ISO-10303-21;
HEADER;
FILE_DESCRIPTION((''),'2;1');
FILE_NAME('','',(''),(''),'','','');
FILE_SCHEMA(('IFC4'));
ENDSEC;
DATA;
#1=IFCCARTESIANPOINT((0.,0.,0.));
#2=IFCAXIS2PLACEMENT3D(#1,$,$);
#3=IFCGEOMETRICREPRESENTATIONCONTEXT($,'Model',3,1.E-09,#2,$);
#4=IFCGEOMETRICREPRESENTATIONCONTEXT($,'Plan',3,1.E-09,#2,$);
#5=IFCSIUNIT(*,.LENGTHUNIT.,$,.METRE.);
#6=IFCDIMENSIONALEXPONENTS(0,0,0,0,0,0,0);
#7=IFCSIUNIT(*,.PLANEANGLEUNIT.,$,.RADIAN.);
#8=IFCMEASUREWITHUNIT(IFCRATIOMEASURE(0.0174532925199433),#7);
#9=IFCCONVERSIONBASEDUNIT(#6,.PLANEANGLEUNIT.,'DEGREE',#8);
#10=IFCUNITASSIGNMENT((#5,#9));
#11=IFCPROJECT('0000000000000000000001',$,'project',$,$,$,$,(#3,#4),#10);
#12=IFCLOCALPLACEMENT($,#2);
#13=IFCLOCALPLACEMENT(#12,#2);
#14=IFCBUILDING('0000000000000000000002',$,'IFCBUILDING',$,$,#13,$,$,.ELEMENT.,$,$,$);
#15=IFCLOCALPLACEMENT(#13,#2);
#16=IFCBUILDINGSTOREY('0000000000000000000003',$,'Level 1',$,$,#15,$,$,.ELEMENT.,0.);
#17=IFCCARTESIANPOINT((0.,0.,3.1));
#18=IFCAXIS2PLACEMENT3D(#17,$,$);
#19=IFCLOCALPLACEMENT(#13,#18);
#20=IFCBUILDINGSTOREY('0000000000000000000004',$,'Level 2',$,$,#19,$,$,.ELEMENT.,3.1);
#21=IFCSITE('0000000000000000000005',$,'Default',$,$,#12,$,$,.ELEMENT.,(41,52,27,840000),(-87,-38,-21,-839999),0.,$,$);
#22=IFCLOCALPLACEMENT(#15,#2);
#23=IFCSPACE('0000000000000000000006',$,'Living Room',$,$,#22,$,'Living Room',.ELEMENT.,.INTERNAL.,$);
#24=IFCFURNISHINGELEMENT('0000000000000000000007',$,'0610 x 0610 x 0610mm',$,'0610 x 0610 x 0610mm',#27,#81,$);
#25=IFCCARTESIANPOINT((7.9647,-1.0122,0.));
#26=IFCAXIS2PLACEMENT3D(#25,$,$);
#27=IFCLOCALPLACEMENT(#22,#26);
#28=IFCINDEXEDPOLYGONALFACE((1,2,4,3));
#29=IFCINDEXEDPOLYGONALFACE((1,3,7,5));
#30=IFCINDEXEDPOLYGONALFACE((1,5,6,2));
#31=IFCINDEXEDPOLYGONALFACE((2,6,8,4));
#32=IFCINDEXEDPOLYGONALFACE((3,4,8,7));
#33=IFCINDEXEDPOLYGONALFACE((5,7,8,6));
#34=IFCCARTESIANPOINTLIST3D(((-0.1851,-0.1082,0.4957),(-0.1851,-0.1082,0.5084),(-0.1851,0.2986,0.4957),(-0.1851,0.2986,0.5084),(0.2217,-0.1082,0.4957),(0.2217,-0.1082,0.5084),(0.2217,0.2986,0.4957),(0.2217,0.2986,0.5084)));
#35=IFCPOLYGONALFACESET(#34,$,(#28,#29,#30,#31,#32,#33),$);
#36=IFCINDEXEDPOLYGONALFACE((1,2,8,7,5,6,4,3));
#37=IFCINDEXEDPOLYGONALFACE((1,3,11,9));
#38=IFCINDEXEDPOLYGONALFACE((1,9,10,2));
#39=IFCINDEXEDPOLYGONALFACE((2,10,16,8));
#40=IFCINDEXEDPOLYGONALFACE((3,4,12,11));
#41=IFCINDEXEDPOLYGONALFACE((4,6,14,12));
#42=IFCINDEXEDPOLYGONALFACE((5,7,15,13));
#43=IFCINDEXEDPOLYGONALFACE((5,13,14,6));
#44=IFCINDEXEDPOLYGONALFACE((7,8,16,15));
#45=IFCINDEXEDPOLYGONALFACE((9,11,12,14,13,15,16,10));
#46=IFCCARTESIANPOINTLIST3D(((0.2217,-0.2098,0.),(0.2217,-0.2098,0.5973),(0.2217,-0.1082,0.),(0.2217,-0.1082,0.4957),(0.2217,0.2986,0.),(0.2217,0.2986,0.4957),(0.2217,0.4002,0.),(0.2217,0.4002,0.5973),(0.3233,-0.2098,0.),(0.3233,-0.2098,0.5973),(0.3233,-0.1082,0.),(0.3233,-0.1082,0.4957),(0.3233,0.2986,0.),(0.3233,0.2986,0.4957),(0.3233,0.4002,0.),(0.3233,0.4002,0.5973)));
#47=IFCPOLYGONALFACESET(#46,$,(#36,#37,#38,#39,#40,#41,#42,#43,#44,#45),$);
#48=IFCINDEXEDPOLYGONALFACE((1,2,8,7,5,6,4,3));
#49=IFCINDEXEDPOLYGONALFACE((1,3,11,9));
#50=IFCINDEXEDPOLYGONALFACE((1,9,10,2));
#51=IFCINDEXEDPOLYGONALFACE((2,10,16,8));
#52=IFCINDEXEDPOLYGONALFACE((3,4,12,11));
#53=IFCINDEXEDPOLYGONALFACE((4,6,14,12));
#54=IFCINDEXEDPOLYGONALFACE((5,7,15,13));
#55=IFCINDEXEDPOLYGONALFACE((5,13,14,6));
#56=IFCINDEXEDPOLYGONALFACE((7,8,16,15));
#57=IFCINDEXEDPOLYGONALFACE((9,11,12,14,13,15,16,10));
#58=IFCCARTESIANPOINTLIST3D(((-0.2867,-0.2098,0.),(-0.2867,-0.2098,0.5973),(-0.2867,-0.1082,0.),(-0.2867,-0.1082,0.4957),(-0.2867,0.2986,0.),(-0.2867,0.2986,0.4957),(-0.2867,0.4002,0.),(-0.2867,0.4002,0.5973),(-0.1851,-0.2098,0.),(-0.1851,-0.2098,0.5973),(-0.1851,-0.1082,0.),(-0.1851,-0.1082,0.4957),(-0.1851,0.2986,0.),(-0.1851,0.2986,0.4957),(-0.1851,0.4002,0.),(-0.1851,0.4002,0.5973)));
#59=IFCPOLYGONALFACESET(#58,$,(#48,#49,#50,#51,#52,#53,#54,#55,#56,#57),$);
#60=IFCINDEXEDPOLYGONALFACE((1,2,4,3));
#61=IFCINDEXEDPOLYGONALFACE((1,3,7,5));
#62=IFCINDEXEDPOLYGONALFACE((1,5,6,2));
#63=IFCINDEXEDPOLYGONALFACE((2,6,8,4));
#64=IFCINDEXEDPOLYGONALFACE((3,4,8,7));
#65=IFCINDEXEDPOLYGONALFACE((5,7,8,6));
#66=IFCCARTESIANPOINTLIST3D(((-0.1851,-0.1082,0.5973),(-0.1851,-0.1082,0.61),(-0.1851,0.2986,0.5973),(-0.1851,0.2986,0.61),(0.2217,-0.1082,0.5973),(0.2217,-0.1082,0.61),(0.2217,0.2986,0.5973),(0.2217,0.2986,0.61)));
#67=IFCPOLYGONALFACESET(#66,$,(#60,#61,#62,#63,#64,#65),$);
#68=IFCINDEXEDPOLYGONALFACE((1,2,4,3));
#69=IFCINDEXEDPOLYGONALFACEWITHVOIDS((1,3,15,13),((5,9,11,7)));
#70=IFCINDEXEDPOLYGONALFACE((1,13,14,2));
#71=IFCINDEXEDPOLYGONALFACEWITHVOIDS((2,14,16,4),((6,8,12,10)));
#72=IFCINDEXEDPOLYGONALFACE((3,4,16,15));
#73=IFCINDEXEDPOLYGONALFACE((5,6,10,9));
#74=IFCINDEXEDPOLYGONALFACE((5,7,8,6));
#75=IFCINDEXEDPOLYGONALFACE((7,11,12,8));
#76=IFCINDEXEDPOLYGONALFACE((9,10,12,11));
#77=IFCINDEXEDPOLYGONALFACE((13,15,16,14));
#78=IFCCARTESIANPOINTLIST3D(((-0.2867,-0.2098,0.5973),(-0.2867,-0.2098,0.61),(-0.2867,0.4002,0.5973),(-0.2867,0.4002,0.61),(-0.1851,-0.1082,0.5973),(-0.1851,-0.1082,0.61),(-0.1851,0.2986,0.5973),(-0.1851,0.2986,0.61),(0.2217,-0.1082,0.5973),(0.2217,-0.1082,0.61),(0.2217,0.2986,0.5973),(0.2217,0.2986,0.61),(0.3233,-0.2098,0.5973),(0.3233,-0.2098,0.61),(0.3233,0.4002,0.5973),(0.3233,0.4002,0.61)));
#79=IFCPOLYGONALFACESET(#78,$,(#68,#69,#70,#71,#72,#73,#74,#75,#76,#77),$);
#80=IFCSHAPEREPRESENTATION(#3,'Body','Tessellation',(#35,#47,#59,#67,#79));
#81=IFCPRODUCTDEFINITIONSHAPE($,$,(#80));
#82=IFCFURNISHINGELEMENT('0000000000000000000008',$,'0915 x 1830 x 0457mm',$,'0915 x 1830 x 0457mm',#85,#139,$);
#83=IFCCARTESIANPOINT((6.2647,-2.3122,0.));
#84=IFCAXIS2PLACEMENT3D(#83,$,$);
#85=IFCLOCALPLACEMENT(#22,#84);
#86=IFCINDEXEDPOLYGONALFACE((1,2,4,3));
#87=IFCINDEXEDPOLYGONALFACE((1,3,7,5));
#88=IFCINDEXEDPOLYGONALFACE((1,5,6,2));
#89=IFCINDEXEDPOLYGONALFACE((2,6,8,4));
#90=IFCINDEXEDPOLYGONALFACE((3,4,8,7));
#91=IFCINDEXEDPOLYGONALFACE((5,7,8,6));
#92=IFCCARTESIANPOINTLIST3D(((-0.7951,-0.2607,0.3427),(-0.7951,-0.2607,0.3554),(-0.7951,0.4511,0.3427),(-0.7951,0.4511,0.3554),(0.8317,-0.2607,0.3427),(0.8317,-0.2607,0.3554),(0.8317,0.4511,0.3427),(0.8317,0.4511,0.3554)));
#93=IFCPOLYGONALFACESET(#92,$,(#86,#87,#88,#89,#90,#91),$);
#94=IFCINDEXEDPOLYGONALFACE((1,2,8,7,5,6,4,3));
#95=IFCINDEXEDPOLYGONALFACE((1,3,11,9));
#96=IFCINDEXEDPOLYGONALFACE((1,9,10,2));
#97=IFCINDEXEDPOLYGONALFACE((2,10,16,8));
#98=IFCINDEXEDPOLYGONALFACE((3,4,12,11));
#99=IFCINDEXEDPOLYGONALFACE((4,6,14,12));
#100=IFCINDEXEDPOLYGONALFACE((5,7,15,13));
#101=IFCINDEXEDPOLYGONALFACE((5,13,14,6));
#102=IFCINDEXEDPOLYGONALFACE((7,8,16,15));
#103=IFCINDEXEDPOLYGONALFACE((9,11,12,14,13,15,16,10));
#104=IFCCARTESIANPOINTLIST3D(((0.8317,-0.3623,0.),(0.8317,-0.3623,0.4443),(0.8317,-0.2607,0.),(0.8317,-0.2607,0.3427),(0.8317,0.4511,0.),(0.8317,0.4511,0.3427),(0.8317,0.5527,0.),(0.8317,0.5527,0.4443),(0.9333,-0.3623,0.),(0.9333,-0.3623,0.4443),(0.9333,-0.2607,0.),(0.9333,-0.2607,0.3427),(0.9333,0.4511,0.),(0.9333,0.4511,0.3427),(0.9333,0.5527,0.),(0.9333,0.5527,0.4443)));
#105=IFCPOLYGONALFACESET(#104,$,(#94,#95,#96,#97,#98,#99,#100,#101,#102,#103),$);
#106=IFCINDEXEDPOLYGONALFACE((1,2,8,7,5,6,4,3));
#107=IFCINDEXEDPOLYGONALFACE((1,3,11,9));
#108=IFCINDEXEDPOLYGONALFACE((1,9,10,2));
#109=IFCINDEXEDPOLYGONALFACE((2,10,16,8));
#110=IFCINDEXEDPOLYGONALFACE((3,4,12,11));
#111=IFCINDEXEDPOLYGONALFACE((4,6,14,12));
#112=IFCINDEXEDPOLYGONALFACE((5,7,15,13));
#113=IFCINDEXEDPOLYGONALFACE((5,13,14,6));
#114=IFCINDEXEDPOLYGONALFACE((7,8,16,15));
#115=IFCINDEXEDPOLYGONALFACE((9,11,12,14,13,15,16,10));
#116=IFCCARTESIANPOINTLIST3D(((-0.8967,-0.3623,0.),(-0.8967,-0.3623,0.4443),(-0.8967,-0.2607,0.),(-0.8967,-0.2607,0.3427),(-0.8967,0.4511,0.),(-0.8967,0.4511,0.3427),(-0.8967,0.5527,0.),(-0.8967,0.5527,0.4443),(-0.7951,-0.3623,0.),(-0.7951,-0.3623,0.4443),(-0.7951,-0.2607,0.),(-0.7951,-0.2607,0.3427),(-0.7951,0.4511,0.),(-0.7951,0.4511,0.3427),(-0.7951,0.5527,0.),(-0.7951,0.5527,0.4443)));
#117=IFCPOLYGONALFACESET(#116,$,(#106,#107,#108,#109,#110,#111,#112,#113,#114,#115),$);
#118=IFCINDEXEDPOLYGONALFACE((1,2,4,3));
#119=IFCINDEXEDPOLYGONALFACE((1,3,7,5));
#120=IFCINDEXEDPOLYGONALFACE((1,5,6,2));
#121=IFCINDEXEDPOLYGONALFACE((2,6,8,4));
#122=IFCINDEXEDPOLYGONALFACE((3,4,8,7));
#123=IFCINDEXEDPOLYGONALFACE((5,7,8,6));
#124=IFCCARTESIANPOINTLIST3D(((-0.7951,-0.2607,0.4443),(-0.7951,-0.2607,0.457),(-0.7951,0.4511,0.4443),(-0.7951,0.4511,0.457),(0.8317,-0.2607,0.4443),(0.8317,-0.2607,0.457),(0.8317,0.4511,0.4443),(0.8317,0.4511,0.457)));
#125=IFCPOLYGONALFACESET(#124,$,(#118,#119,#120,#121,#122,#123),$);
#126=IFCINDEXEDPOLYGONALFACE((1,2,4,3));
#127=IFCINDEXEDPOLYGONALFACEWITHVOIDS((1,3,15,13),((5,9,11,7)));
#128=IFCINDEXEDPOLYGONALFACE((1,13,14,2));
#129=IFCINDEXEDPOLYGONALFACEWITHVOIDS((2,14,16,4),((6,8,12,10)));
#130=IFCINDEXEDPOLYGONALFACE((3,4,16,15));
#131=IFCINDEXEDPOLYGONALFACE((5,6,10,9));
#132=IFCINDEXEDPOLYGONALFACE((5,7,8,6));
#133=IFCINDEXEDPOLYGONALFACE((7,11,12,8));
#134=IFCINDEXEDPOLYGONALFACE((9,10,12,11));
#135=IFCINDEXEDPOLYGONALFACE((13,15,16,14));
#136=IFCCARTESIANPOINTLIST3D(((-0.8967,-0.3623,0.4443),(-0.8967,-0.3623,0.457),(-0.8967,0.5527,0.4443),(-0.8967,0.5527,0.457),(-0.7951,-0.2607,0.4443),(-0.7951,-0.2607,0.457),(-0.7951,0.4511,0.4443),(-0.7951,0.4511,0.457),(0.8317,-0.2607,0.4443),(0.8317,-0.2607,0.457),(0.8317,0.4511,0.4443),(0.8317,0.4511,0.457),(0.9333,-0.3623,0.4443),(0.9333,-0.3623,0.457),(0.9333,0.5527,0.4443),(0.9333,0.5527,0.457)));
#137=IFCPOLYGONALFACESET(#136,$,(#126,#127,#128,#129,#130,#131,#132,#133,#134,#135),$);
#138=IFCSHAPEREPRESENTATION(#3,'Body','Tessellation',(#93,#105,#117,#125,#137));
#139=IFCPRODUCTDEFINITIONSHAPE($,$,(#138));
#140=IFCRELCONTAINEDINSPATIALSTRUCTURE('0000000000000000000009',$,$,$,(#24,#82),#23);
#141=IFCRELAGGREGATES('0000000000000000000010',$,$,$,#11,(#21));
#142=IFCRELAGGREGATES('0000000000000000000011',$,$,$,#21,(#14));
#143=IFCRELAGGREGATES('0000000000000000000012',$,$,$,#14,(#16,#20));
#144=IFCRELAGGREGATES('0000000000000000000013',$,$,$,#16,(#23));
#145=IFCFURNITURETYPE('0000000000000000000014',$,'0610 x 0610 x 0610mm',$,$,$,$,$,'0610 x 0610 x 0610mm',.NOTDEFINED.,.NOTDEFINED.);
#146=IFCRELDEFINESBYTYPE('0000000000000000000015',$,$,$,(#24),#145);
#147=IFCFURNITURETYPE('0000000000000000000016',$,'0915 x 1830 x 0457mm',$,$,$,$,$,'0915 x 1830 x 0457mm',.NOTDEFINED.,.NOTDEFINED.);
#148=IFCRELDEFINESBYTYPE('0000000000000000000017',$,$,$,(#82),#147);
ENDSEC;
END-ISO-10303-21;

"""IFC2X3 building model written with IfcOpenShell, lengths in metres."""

from ifc_helpers import new_model, entity, si_unit, converted_unit, frame, origin, origin_2d_with_axis, place, context, project, spatial, polyline, rectangle, outline, extrude, source, transform, mapped, type_object, type_shapes, element, save


model = new_model("IFC2X3")

# Units and contexts
model_context = context("Model", 3, precision=1e-09, world=origin())
plan_context = context("Plan", 3, precision=1e-09, world=origin())
ifc_project = project(units=[si_unit("LENGTHUNIT", "METRE"), converted_unit("PLANEANGLEUNIT", "DEGREE", entity("IfcRatioMeasure", 0.0174532925199433), si_unit("PLANEANGLEUNIT", "RADIAN"), dimensions=[0, 0, 0, 0, 0, 0, 0])], contexts=[model_context, plan_context])

# Site, building, storey
site_placement = place(None, origin())
site = spatial("IfcSite", under=ifc_project, at=site_placement, Name="Default", CompositionType="ELEMENT", RefLatitude=(41, 52, 27, 840000), RefLongitude=(-87, -38, -21, -839999), RefElevation=0.0)
building_placement = place(site_placement, origin())
building = spatial("IfcBuilding", under=site, at=building_placement, Name="IFCBUILDING", CompositionType="ELEMENT")
storey_1_placement = place(building_placement, origin())
storey_1 = spatial("IfcBuildingStorey", under=building, at=storey_1_placement, Name="Level 1", CompositionType="ELEMENT", Elevation=0.0)

# Shared definitions
storey_2_placement = place(building_placement, frame((0.0, 0.0, 3.1)))
storey_2 = spatial("IfcBuildingStorey", under=building, at=storey_2_placement, Name="Level 2", CompositionType="ELEMENT", Elevation=3.1)

# Shared definitions
space_1_placement = place(storey_1_placement, origin())
space_1 = spatial("IfcSpace", under=storey_1, at=space_1_placement, Name="Living Room", LongName="Living Room", CompositionType="ELEMENT", InteriorOrExteriorSpace="INTERNAL")

# Furnishing elements
furniture_type_1 = type_object("IfcFurnitureType", Name="0610 x 0610 x 0610mm", ElementType="0610 x 0610 x 0610mm", AssemblyPlace="NOTDEFINED")
shared_shape_1 = source(origin(), model_context, "Body", "SweptSolid", [
    extrude(rectangle(XDim=0.4068, YDim=0.4068, at=origin_2d_with_axis()), frame((0.0183, 0.0952, 0.4957), z_axis=(0.0, 0.0, 1.0), x_axis=(-1.0, 0.0, 0.0)), (0.0, 0.0, 1.0), 0.0127),
    extrude(outline(polyline([(-0.2732, -0.305), (0.324, -0.305), (0.324, 0.305), (-0.2732, 0.305), (-0.2732, 0.2034), (0.2225, 0.2034), (0.2225, -0.2034), (-0.2732, -0.2034), (-0.2732, -0.305)])), frame((0.2217, 0.0952, 0.2732), z_axis=(1.0, 0.0, 0.0), x_axis=(0.0, 0.0, 1.0)), (0.0, 0.0, 1.0), 0.1016),
    extrude(outline(polyline([(-0.305, -0.3241), (0.305, -0.3241), (0.305, 0.2733), (0.2034, 0.2733), (0.2034, -0.2224), (-0.2034, -0.2224), (-0.2034, 0.2733), (-0.305, 0.2733), (-0.305, -0.3241)])), frame((-0.2867, 0.0952, 0.2733), z_axis=(1.0, 0.0, 0.0), x_axis=(0.0, -1.0, 0.0)), (0.0, 0.0, 1.0), 0.1016),
    extrude(rectangle(XDim=0.4068, YDim=0.4068, at=origin_2d_with_axis()), frame((0.0183, 0.0952, 0.5973), z_axis=(0.0, 0.0, 1.0), x_axis=(-1.0, 0.0, 0.0)), (0.0, 0.0, 1.0), 0.0127),
    extrude(outline(polyline([(-0.305, -0.305), (0.305, -0.305), (0.305, 0.305), (-0.305, 0.305), (-0.305, -0.305)]), holes=[polyline([(-0.2034, -0.2034), (-0.2034, 0.2034), (0.2034, 0.2034), (0.2034, -0.2034), (-0.2034, -0.2034)])]), frame((0.0183, 0.0952, 0.5973), z_axis=(0.0, 0.0, 1.0), x_axis=(-1.0, 0.0, 0.0)), (0.0, 0.0, 1.0), 0.0127),
])
type_shapes(furniture_type_1, [shared_shape_1])
for number, where, name in (
    (1, (7.9647, -1.0122, 0.0), "0610 x 0610 x 0610mm"),
):
    element("IfcFurnishingElement", number, at=place(space_1_placement, frame(where)), inside=space_1, type_object=furniture_type_1, Name=name, ObjectType="0610 x 0610 x 0610mm", context=model_context, shape_type="MappedRepresentation", body=[
        mapped(shared_shape_1, transform((0.0, 0.0, 0.0), scale=1.0)),
    ])
furniture_type_2 = type_object("IfcFurnitureType", Name="0915 x 1830 x 0457mm", ElementType="0915 x 1830 x 0457mm", AssemblyPlace="NOTDEFINED")
shared_shape_2 = source(origin(), model_context, "Body", "SweptSolid", [
    extrude(rectangle(XDim=1.6268, YDim=0.7118, at=origin_2d_with_axis()), frame((0.0183, 0.0952, 0.3427), z_axis=(0.0, 0.0, 1.0), x_axis=(-1.0, 0.0, 0.0)), (0.0, 0.0, 1.0), 0.0127),
    extrude(outline(polyline([(-0.1967, -0.4575), (0.2475, -0.4575), (0.2475, 0.4575), (-0.1967, 0.4575), (-0.1967, 0.3559), (0.146, 0.3559), (0.146, -0.3559), (-0.1967, -0.3559), (-0.1967, -0.4575)])), frame((0.8317, 0.0952, 0.1967), z_axis=(1.0, 0.0, 0.0), x_axis=(0.0, 0.0, 1.0)), (0.0, 0.0, 1.0), 0.1016),
    extrude(outline(polyline([(-0.4575, -0.2476), (0.4575, -0.2476), (0.4575, 0.1968), (0.3559, 0.1968), (0.3559, -0.1459), (-0.3559, -0.1459), (-0.3559, 0.1968), (-0.4575, 0.1968), (-0.4575, -0.2476)])), frame((-0.8967, 0.0952, 0.1968), z_axis=(1.0, 0.0, 0.0), x_axis=(0.0, -1.0, 0.0)), (0.0, 0.0, 1.0), 0.1016),
    extrude(rectangle(XDim=1.6268, YDim=0.7118, at=origin_2d_with_axis()), frame((0.0183, 0.0952, 0.4443), z_axis=(0.0, 0.0, 1.0), x_axis=(-1.0, 0.0, 0.0)), (0.0, 0.0, 1.0), 0.0127),
    extrude(outline(polyline([(-0.915, -0.4575), (0.915, -0.4575), (0.915, 0.4575), (-0.915, 0.4575), (-0.915, -0.4575)]), holes=[polyline([(-0.8134, -0.3559), (-0.8134, 0.3559), (0.8134, 0.3559), (0.8134, -0.3559), (-0.8134, -0.3559)])]), frame((0.0183, 0.0952, 0.4443), z_axis=(0.0, 0.0, 1.0), x_axis=(-1.0, 0.0, 0.0)), (0.0, 0.0, 1.0), 0.0127),
])
type_shapes(furniture_type_2, [shared_shape_2])
furnishing_1_placement = place(space_1_placement, frame((6.2647, -2.3122, 0.0)))
element("IfcFurnishingElement", 2, at=furnishing_1_placement, inside=space_1, type_object=furniture_type_2, Name="0915 x 1830 x 0457mm", ObjectType="0915 x 1830 x 0457mm", context=model_context, shape_type="MappedRepresentation", body=[
    mapped(shared_shape_2, transform((0.0, 0.0, 0.0), scale=1.0)),
])

save(model, "model.ifc")
